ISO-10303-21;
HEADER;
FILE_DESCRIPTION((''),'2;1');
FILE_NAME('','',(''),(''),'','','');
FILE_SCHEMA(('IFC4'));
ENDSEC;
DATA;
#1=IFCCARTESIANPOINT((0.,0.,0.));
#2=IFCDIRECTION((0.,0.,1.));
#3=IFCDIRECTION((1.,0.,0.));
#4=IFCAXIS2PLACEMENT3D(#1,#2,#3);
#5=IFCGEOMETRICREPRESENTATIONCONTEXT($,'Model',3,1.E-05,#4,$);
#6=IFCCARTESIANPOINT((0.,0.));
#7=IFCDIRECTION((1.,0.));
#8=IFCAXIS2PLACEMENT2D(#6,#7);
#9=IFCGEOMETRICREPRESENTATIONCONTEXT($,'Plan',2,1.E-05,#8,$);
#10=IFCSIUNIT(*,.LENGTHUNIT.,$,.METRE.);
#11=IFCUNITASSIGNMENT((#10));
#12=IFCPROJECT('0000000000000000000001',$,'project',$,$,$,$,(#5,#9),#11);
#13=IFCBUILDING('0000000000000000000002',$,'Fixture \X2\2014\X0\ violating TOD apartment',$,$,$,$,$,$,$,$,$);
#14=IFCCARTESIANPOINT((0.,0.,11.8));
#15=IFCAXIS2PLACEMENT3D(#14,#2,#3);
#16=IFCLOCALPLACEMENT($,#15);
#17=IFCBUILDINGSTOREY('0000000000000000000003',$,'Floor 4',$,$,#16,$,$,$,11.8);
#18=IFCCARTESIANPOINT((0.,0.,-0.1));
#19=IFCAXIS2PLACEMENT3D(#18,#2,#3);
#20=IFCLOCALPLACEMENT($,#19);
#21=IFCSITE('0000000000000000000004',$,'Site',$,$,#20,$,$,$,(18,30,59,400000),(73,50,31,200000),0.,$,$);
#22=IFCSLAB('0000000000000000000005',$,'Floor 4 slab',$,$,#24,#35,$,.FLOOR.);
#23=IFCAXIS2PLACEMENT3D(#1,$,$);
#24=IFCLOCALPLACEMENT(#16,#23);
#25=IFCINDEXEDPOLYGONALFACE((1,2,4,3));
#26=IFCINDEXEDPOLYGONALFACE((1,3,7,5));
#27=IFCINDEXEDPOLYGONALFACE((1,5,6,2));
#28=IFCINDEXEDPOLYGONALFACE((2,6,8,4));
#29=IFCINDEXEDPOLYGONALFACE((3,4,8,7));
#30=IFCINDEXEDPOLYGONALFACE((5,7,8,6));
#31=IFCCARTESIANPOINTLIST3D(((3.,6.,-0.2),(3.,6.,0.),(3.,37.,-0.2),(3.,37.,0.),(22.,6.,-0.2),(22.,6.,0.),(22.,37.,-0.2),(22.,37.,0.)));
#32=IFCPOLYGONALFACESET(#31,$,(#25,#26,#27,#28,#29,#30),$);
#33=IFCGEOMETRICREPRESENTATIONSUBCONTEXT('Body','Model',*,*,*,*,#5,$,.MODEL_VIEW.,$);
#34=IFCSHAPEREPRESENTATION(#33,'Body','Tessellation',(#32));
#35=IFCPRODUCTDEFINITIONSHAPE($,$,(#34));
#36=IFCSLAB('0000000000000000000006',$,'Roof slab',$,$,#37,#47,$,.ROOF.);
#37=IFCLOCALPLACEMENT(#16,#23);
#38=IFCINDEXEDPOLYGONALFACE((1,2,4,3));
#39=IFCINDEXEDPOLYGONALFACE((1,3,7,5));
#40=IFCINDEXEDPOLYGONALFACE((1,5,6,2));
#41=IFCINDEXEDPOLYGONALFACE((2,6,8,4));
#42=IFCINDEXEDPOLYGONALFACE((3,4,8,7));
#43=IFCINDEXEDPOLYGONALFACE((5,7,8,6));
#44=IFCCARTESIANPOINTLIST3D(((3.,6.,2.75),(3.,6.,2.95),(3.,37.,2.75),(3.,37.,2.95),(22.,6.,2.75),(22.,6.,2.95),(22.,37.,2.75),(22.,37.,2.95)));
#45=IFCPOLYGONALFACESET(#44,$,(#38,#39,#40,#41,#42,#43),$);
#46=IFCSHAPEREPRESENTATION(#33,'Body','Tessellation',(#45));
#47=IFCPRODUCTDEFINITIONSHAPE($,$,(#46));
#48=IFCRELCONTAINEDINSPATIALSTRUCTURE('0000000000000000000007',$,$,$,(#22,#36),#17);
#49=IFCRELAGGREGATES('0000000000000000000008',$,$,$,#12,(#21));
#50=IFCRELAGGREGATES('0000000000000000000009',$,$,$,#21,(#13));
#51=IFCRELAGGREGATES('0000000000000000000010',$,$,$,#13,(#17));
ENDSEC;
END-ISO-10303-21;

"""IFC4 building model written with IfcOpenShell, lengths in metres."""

from ifc_helpers import new_model, si_unit, frame, origin_with_axes, origin_2d_with_axis, place, context, subcontext, project, spatial, line, indexed_curve, outline, extrude, element, save


model = new_model("IFC4")

# Units and contexts
model_context = context("Model", 3, precision=1e-05, world=origin_with_axes())
plan_context = context("Plan", 2, precision=1e-05, world=origin_2d_with_axis())
body_context = subcontext(model_context, "Body", "Model", "MODEL_VIEW")
ifc_project = project(units=[si_unit("LENGTHUNIT", "METRE")], contexts=[model_context, plan_context])

# Site, building, storey
site_placement = place(None, frame((0.0, 0.0, -0.1), z_axis=(0.0, 0.0, 1.0), x_axis=(1.0, 0.0, 0.0)))
site = spatial("IfcSite", under=ifc_project, at=site_placement, Name="Site", RefLatitude=(18, 30, 59, 400000), RefLongitude=(73, 50, 31, 200000), RefElevation=0.0)
building = spatial("IfcBuilding", under=site, Name="Fixture — violating TOD apartment")
storey_placement = place(None, frame((0.0, 0.0, 11.8), z_axis=(0.0, 0.0, 1.0), x_axis=(1.0, 0.0, 0.0)))
storey = spatial("IfcBuildingStorey", under=building, at=storey_placement, Name="Floor 4", Elevation=11.8)

# Slabs
slab_1_placement = place(storey_placement, frame((0.0, 0.0, -0.2), z_axis=(0.0, 0.0, 1.0), x_axis=(1.0, 0.0, 0.0)))
element("IfcSlab", 1, at=slab_1_placement, inside=storey, Name="Floor 4 slab", PredefinedType="FLOOR", context=body_context, shape_type="SweptSolid", body=[
    extrude(outline(indexed_curve([(3.0, 6.0), (22.0, 6.0), (22.0, 37.0), (3.0, 37.0)], segments=[line(1, 2, 3, 4, 1)])), origin_with_axes(), (0.0, 0.0, 1.0), 0.2),
])
slab_2_placement = place(storey_placement, frame((0.0, 0.0, 2.75), z_axis=(0.0, 0.0, 1.0), x_axis=(1.0, 0.0, 0.0)))
element("IfcSlab", 2, at=slab_2_placement, inside=storey, Name="Roof slab", PredefinedType="ROOF", context=body_context, shape_type="SweptSolid", body=[
    extrude(outline(indexed_curve([(3.0, 6.0), (22.0, 6.0), (22.0, 37.0), (3.0, 37.0)], segments=[line(1, 2, 3, 4, 1)])), origin_with_axes(), (0.0, 0.0, 1.0), 0.2),
])

save(model, "model.ifc")
